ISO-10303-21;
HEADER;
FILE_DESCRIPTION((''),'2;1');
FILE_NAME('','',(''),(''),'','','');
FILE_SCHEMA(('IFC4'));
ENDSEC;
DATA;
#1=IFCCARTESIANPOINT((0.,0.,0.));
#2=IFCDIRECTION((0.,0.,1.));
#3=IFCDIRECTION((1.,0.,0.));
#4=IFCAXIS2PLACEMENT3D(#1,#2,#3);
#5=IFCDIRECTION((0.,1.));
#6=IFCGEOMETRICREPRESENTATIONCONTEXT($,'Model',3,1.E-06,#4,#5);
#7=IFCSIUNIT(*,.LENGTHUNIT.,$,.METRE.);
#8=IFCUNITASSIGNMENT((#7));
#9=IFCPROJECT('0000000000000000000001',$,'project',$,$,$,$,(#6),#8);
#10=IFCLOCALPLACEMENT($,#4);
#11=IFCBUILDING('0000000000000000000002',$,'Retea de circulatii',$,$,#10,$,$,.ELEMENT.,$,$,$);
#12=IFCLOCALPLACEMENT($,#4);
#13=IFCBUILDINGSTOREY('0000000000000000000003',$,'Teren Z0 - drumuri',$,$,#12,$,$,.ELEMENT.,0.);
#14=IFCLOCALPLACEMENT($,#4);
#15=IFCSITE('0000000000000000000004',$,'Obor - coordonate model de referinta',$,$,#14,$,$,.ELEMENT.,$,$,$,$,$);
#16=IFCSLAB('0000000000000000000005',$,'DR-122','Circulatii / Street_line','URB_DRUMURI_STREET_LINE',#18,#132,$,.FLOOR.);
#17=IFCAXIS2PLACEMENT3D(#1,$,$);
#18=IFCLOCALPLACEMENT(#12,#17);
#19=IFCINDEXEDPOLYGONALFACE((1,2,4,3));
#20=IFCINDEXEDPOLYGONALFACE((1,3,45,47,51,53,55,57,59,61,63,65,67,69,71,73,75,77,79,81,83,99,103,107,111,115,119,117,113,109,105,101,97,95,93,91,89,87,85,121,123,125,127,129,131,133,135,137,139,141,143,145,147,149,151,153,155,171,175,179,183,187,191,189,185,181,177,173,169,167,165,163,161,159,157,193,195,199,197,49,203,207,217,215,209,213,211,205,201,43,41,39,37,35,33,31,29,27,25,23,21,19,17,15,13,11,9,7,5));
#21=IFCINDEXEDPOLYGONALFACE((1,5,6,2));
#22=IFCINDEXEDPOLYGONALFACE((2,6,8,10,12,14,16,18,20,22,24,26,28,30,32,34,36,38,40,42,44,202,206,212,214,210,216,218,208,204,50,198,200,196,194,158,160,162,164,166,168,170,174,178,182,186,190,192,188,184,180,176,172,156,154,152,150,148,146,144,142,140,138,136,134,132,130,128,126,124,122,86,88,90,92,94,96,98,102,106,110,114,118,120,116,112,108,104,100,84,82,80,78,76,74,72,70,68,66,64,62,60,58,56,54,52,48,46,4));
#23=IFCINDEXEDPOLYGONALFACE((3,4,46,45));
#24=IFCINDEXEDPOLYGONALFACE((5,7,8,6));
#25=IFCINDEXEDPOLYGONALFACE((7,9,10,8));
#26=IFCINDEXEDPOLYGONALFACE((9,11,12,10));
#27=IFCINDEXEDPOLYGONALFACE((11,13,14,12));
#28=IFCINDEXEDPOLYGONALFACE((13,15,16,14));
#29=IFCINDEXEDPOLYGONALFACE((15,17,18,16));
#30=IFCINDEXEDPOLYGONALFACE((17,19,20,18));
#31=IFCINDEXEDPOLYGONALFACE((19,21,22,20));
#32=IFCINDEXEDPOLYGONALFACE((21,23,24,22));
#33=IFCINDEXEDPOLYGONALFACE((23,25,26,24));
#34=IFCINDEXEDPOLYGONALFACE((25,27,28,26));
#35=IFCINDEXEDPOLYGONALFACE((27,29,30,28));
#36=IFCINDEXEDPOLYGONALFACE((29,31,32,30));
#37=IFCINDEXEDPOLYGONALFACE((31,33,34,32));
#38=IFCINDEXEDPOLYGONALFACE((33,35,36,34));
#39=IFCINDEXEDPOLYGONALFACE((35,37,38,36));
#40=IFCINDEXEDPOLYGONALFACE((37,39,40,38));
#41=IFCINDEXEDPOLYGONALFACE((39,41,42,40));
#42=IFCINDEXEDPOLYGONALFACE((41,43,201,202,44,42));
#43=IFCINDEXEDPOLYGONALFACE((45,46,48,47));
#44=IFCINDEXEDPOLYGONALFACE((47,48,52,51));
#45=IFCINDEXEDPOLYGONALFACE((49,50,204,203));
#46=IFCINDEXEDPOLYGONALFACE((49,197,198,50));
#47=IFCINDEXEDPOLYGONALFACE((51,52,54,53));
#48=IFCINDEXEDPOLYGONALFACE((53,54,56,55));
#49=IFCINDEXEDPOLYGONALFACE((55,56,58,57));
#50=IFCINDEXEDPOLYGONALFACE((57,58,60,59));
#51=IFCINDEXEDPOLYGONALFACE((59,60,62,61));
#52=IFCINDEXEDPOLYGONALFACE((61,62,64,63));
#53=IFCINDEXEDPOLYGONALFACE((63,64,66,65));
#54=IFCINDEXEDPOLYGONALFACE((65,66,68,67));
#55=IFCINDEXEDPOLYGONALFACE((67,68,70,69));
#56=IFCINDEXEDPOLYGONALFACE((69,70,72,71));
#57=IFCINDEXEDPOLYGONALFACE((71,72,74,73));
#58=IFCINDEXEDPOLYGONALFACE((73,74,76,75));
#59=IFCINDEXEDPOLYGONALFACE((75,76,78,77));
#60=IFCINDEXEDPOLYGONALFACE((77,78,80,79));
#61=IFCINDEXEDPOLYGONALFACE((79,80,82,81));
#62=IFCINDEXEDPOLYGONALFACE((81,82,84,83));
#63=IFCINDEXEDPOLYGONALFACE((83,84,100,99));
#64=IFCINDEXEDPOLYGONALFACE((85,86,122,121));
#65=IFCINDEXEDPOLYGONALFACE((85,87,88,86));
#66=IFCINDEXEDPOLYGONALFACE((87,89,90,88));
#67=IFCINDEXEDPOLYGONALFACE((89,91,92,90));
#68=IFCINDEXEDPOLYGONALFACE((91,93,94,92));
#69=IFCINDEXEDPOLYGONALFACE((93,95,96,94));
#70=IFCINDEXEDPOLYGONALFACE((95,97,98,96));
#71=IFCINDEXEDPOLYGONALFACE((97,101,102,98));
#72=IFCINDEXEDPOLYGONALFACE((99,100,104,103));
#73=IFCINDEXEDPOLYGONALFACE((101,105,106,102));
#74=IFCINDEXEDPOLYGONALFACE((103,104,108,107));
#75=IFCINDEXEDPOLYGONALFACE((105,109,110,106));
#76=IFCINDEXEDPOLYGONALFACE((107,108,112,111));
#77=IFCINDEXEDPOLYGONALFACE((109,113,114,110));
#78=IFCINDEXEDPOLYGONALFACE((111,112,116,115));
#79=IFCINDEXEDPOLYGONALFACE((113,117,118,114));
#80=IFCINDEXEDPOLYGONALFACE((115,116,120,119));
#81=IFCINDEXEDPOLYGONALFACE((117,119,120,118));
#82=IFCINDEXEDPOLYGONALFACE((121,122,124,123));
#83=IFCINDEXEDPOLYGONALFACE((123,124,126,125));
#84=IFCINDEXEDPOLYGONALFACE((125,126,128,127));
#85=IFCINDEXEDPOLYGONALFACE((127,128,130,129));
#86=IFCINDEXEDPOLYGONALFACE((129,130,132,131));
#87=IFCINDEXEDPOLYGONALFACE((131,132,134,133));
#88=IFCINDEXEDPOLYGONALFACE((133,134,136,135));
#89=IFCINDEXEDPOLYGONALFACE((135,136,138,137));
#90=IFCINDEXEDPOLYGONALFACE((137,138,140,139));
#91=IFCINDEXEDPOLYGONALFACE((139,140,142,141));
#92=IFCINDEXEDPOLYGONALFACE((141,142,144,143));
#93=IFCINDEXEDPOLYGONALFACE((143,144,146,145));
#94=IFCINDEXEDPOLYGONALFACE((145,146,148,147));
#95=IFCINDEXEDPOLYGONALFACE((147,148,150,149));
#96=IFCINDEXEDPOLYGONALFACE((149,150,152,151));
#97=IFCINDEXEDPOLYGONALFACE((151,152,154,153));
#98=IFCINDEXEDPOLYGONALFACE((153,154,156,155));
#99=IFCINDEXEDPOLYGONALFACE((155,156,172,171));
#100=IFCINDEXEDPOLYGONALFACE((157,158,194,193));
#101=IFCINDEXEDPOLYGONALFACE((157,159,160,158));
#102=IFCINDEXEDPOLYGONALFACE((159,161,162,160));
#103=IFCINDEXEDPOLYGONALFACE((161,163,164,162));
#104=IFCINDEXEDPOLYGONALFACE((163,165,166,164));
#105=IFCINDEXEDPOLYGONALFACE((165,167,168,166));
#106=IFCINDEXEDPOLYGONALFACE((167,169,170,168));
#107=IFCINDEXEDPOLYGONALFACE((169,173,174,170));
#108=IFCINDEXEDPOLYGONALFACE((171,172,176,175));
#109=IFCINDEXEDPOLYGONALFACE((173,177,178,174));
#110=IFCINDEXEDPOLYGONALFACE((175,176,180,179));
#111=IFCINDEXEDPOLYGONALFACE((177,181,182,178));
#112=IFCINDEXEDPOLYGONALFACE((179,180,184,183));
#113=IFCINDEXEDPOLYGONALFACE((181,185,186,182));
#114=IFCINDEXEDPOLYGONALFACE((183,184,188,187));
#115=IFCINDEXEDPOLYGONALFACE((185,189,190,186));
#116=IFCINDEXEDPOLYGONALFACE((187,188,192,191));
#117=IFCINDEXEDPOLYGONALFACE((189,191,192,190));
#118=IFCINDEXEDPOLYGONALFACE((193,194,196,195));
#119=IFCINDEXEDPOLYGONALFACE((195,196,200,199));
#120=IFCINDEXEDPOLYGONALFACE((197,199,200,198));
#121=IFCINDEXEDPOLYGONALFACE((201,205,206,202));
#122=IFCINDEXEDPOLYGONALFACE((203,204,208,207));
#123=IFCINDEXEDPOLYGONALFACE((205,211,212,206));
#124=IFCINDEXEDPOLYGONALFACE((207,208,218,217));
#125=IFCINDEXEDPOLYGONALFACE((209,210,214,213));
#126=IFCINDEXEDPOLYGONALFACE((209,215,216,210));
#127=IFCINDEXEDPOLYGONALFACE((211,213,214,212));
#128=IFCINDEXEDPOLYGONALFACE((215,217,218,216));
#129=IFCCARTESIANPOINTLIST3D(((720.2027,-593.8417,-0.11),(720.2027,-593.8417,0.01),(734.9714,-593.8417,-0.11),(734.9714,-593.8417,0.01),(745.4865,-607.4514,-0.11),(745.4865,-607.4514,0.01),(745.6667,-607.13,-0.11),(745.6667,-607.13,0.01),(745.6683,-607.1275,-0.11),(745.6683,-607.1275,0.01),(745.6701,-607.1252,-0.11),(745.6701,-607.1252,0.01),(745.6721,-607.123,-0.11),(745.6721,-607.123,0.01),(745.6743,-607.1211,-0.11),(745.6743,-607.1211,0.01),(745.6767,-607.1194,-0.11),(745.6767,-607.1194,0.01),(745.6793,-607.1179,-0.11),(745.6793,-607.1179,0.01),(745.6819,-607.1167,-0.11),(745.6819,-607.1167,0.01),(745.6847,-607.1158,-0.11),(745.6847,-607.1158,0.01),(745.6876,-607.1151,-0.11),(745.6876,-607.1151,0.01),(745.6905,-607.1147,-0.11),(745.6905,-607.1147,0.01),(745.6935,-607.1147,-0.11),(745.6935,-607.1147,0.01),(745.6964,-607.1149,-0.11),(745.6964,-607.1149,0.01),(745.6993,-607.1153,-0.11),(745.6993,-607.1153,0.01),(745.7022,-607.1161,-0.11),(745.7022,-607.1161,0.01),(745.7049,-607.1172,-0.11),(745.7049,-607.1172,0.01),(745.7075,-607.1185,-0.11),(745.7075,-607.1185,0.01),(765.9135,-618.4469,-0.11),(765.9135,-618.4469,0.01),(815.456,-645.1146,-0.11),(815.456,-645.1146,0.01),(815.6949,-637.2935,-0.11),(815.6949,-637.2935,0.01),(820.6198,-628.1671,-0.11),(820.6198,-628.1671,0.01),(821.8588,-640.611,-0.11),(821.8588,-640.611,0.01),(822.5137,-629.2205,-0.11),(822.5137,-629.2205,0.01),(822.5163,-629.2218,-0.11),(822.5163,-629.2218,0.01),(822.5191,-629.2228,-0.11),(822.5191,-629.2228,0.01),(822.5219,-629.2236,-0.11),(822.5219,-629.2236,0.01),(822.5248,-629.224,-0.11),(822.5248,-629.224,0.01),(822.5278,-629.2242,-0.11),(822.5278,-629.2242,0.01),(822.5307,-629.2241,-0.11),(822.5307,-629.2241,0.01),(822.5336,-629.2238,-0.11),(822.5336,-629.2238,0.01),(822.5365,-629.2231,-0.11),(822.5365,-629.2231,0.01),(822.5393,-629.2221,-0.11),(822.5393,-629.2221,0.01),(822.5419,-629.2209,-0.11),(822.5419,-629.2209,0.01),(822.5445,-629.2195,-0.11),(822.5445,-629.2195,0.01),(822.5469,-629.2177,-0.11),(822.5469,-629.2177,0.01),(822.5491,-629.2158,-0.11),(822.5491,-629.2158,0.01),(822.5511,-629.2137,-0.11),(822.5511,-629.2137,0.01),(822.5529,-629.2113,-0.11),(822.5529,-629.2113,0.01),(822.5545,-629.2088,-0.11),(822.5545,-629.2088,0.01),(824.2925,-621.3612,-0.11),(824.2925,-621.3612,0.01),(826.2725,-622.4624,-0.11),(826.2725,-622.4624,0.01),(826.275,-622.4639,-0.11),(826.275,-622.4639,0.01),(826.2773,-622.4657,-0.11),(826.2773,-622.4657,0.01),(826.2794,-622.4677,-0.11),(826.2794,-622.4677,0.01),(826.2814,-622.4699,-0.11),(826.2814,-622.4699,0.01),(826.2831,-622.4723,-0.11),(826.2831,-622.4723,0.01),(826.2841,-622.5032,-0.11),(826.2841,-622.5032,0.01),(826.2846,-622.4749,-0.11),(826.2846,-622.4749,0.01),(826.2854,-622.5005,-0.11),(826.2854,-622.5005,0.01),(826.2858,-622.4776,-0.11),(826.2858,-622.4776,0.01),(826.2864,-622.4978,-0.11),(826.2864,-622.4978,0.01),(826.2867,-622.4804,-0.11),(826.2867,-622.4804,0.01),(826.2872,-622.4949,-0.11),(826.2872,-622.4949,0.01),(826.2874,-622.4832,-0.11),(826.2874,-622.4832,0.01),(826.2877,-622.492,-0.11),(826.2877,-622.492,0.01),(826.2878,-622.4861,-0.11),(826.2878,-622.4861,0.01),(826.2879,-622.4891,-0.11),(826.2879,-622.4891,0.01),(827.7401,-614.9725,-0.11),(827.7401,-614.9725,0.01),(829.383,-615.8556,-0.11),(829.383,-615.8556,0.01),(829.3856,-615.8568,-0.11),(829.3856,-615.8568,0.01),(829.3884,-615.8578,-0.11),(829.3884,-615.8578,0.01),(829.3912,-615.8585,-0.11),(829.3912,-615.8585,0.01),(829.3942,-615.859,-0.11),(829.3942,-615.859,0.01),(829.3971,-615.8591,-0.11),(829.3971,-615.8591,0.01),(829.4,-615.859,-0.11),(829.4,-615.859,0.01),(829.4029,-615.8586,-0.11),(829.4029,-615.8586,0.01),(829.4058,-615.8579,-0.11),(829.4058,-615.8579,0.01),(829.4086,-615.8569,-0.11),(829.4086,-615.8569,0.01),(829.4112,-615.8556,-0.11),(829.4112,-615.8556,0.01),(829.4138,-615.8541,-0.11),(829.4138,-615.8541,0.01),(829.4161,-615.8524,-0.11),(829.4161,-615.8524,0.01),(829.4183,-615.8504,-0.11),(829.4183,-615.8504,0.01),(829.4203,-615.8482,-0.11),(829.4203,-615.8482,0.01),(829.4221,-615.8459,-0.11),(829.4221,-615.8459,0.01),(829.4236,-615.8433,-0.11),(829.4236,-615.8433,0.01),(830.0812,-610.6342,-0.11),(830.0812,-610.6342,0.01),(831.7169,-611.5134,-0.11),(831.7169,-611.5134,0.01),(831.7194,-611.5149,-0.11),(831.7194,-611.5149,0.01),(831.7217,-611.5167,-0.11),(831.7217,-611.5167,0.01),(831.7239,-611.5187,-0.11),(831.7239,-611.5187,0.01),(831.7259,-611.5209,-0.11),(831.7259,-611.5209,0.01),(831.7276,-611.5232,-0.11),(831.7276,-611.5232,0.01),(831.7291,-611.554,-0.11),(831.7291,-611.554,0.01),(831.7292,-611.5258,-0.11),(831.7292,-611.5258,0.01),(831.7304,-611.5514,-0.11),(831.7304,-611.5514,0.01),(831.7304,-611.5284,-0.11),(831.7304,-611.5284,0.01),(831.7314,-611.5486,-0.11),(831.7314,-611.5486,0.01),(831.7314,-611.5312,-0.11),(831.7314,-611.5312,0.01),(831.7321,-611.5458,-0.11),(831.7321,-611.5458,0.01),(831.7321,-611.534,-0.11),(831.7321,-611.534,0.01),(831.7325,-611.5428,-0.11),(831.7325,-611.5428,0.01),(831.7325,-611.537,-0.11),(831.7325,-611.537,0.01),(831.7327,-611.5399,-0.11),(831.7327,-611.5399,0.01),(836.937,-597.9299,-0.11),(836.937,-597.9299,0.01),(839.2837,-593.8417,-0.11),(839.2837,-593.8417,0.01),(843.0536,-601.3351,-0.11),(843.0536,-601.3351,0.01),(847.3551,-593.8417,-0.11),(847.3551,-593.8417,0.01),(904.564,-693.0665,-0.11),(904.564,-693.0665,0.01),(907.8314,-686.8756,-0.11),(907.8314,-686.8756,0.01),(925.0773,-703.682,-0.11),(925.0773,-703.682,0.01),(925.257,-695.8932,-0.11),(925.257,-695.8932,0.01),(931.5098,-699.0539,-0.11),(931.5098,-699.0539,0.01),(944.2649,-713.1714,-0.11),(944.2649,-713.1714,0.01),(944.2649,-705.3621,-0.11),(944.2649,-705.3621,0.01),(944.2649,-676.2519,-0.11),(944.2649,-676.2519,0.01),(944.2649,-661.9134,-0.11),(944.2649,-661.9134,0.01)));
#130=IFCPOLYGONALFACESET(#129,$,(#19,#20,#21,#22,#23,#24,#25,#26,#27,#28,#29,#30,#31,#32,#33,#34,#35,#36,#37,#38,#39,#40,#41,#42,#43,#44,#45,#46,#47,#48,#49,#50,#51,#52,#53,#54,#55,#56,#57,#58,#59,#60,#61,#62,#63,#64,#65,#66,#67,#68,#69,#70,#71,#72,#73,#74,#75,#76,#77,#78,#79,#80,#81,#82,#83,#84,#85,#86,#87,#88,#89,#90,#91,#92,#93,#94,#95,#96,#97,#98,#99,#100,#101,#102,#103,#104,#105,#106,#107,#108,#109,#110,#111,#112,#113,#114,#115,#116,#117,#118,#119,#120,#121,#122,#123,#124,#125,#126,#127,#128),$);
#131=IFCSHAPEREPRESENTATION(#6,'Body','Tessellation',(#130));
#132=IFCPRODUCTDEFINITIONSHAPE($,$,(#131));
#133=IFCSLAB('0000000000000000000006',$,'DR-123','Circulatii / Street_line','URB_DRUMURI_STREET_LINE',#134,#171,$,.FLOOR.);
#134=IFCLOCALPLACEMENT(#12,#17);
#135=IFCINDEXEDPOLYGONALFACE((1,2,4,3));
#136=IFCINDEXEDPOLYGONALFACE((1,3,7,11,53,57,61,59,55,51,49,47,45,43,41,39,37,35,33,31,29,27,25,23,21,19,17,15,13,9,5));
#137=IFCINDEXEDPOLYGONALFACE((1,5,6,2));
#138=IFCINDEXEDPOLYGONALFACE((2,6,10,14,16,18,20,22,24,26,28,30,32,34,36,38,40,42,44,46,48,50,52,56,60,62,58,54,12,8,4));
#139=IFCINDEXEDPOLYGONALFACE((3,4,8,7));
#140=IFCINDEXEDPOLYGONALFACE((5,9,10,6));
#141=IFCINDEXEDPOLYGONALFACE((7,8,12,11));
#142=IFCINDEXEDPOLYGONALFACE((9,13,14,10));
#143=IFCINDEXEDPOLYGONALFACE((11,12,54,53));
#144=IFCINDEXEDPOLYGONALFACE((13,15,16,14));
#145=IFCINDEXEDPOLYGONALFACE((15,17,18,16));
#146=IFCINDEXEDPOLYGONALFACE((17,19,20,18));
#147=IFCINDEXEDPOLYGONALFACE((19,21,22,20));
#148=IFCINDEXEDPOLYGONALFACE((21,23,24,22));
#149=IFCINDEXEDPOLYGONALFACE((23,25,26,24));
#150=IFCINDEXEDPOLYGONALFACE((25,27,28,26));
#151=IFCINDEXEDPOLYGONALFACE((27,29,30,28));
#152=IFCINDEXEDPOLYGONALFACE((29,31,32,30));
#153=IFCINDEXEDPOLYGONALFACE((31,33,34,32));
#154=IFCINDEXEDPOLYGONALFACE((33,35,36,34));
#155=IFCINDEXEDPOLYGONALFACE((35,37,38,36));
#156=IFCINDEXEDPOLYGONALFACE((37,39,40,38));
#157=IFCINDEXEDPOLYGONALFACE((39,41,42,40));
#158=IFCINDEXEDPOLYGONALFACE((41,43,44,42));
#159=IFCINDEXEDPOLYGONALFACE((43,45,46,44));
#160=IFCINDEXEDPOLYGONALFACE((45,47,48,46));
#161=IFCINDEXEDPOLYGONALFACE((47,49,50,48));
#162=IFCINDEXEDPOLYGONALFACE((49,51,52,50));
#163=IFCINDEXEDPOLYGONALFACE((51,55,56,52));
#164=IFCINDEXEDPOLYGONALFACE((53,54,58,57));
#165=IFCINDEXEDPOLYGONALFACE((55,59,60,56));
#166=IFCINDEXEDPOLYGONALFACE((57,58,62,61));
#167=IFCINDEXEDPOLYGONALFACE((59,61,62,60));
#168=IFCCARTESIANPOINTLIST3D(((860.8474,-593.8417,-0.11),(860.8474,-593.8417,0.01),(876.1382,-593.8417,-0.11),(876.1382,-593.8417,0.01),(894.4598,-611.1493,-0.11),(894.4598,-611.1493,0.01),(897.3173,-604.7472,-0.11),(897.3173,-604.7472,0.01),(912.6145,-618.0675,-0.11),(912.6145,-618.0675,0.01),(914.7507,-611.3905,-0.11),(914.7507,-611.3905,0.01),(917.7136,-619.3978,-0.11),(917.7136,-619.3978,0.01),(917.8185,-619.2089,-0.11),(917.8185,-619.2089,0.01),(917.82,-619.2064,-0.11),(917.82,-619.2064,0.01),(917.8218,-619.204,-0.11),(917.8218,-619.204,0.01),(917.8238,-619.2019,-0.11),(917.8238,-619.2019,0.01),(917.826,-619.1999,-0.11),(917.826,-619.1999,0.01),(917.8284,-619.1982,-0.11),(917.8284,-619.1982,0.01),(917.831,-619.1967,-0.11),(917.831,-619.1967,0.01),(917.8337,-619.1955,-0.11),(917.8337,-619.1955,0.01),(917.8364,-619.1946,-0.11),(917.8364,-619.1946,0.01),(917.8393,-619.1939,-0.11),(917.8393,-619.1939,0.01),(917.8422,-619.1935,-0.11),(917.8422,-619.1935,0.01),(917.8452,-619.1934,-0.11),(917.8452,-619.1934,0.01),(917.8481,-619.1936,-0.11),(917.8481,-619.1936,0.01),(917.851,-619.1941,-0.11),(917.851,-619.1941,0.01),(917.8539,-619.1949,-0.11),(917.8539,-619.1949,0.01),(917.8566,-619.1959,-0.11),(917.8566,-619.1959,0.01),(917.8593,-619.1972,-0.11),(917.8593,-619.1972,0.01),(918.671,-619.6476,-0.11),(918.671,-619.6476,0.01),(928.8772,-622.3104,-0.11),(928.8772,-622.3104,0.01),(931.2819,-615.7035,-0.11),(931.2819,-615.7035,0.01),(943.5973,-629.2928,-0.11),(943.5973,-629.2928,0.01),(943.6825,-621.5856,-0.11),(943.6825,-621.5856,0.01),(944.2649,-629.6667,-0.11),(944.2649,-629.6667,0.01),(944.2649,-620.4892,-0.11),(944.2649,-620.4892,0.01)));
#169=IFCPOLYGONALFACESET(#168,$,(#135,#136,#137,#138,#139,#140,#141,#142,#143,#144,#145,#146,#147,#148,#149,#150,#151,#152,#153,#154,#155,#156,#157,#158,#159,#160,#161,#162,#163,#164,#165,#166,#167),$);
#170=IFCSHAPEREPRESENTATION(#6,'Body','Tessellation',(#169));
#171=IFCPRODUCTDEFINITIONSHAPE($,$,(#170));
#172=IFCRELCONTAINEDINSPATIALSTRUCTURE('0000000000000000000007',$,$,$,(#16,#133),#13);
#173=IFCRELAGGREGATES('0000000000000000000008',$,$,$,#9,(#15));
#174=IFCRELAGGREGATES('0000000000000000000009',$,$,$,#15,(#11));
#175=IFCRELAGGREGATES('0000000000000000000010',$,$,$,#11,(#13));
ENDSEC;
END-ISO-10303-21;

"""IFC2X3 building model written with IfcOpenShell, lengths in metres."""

from ifc_helpers import new_model, si_unit, direction, frame, origin_with_axes, place, context, project, spatial, polyline, outline, extrude, element, save


model = new_model("IFC2X3")

# Units and contexts
model_context = context("Model", 3, precision=1e-06, world=origin_with_axes(), true_north=direction((0.0, 1.0)))
ifc_project = project(units=[si_unit("LENGTHUNIT", "METRE")], contexts=[model_context])

# Site, building, storey
site_placement = place(None, origin_with_axes())
site = spatial("IfcSite", under=ifc_project, at=site_placement, Name="Obor - coordonate model de referinta", CompositionType="ELEMENT")
building_placement = place(None, origin_with_axes())
building = spatial("IfcBuilding", under=site, at=building_placement, Name="Retea de circulatii", CompositionType="ELEMENT")
storey_placement = place(None, origin_with_axes())
storey = spatial("IfcBuildingStorey", under=building, at=storey_placement, Name="Teren Z0 - drumuri", CompositionType="ELEMENT", Elevation=0.0)

# Slabs
slab_1_placement = place(None, origin_with_axes())
element("IfcSlab", 1, at=slab_1_placement, inside=storey, Name="DR-122", Description="Circulatii / Street_line", ObjectType="URB_DRUMURI_STREET_LINE", PredefinedType="FLOOR", context=model_context, shape_type="SweptSolid", body=[
    extrude(outline(polyline([(815.456, -645.1146), (904.564, -693.0665), (925.0773, -703.682), (944.2649, -713.1714), (944.2649, -705.3621), (931.5098, -699.0539), (944.2649, -676.2519), (944.2649, -661.9134), (925.257, -695.8932), (907.8314, -686.8756), (821.8588, -640.611), (843.0536, -601.3351), (847.3551, -593.8417), (839.2837, -593.8417), (836.937, -597.9299), (830.0812, -610.6342), (831.7169, -611.5134), (831.7194, -611.5149), (831.7217, -611.5167), (831.7239, -611.5187), (831.7259, -611.5209), (831.7276, -611.5232), (831.7292, -611.5258), (831.7304, -611.5284), (831.7314, -611.5312), (831.7321, -611.534), (831.7325, -611.537), (831.7327, -611.5399), (831.7325, -611.5428), (831.7321, -611.5458), (831.7314, -611.5486), (831.7304, -611.5514), (831.7291, -611.554), (829.4236, -615.8433), (829.4221, -615.8459), (829.4203, -615.8482), (829.4183, -615.8504), (829.4161, -615.8524), (829.4138, -615.8541), (829.4112, -615.8556), (829.4086, -615.8569), (829.4058, -615.8579), (829.4029, -615.8586), (829.4, -615.859), (829.3971, -615.8591), (829.3942, -615.859), (829.3912, -615.8585), (829.3884, -615.8578), (829.3856, -615.8568), (829.383, -615.8556), (827.7401, -614.9725), (824.2925, -621.3612), (826.2725, -622.4624), (826.275, -622.4639), (826.2773, -622.4657), (826.2794, -622.4677), (826.2814, -622.4699), (826.2831, -622.4723), (826.2846, -622.4749), (826.2858, -622.4776), (826.2867, -622.4804), (826.2874, -622.4832), (826.2878, -622.4861), (826.2879, -622.4891), (826.2877, -622.492), (826.2872, -622.4949), (826.2864, -622.4978), (826.2854, -622.5005), (826.2841, -622.5032), (822.5545, -629.2088), (822.5529, -629.2113), (822.5511, -629.2137), (822.5491, -629.2158), (822.5469, -629.2177), (822.5445, -629.2195), (822.5419, -629.2209), (822.5393, -629.2221), (822.5365, -629.2231), (822.5336, -629.2238), (822.5307, -629.2241), (822.5278, -629.2242), (822.5248, -629.224), (822.5219, -629.2236), (822.5191, -629.2228), (822.5163, -629.2218), (822.5137, -629.2205), (820.6198, -628.1671), (815.6949, -637.2935), (734.9714, -593.8417), (720.2027, -593.8417), (745.4865, -607.4514), (745.6667, -607.13), (745.6683, -607.1275), (745.6701, -607.1252), (745.6721, -607.123), (745.6743, -607.1211), (745.6767, -607.1194), (745.6793, -607.1179), (745.6819, -607.1167), (745.6847, -607.1158), (745.6876, -607.1151), (745.6905, -607.1147), (745.6935, -607.1147), (745.6964, -607.1149), (745.6993, -607.1153), (745.7022, -607.1161), (745.7049, -607.1172), (745.7075, -607.1185), (765.9135, -618.4469), (815.456, -645.1146)])), frame((0.0, 0.0, -0.11), z_axis=(0.0, 0.0, 1.0), x_axis=(1.0, 0.0, 0.0)), (0.0, 0.0, 1.0), 0.12),
])
slab_2_placement = place(None, origin_with_axes())
element("IfcSlab", 2, at=slab_2_placement, inside=storey, Name="DR-123", Description="Circulatii / Street_line", ObjectType="URB_DRUMURI_STREET_LINE", PredefinedType="FLOOR", context=model_context, shape_type="SweptSolid", body=[
    extrude(outline(polyline([(943.6825, -621.5856), (931.2819, -615.7035), (914.7507, -611.3905), (897.3173, -604.7472), (876.1382, -593.8417), (860.8474, -593.8417), (894.4598, -611.1493), (912.6145, -618.0675), (917.7136, -619.3978), (917.8185, -619.2089), (917.82, -619.2064), (917.8218, -619.204), (917.8238, -619.2019), (917.826, -619.1999), (917.8284, -619.1982), (917.831, -619.1967), (917.8337, -619.1955), (917.8364, -619.1946), (917.8393, -619.1939), (917.8422, -619.1935), (917.8452, -619.1934), (917.8481, -619.1936), (917.851, -619.1941), (917.8539, -619.1949), (917.8566, -619.1959), (917.8593, -619.1972), (918.671, -619.6476), (928.8772, -622.3104), (943.5973, -629.2928), (944.2649, -629.6667), (944.2649, -620.4892), (943.6825, -621.5856)])), frame((0.0, 0.0, -0.11), z_axis=(0.0, 0.0, 1.0), x_axis=(1.0, 0.0, 0.0)), (0.0, 0.0, 1.0), 0.12),
])

save(model, "model.ifc")
